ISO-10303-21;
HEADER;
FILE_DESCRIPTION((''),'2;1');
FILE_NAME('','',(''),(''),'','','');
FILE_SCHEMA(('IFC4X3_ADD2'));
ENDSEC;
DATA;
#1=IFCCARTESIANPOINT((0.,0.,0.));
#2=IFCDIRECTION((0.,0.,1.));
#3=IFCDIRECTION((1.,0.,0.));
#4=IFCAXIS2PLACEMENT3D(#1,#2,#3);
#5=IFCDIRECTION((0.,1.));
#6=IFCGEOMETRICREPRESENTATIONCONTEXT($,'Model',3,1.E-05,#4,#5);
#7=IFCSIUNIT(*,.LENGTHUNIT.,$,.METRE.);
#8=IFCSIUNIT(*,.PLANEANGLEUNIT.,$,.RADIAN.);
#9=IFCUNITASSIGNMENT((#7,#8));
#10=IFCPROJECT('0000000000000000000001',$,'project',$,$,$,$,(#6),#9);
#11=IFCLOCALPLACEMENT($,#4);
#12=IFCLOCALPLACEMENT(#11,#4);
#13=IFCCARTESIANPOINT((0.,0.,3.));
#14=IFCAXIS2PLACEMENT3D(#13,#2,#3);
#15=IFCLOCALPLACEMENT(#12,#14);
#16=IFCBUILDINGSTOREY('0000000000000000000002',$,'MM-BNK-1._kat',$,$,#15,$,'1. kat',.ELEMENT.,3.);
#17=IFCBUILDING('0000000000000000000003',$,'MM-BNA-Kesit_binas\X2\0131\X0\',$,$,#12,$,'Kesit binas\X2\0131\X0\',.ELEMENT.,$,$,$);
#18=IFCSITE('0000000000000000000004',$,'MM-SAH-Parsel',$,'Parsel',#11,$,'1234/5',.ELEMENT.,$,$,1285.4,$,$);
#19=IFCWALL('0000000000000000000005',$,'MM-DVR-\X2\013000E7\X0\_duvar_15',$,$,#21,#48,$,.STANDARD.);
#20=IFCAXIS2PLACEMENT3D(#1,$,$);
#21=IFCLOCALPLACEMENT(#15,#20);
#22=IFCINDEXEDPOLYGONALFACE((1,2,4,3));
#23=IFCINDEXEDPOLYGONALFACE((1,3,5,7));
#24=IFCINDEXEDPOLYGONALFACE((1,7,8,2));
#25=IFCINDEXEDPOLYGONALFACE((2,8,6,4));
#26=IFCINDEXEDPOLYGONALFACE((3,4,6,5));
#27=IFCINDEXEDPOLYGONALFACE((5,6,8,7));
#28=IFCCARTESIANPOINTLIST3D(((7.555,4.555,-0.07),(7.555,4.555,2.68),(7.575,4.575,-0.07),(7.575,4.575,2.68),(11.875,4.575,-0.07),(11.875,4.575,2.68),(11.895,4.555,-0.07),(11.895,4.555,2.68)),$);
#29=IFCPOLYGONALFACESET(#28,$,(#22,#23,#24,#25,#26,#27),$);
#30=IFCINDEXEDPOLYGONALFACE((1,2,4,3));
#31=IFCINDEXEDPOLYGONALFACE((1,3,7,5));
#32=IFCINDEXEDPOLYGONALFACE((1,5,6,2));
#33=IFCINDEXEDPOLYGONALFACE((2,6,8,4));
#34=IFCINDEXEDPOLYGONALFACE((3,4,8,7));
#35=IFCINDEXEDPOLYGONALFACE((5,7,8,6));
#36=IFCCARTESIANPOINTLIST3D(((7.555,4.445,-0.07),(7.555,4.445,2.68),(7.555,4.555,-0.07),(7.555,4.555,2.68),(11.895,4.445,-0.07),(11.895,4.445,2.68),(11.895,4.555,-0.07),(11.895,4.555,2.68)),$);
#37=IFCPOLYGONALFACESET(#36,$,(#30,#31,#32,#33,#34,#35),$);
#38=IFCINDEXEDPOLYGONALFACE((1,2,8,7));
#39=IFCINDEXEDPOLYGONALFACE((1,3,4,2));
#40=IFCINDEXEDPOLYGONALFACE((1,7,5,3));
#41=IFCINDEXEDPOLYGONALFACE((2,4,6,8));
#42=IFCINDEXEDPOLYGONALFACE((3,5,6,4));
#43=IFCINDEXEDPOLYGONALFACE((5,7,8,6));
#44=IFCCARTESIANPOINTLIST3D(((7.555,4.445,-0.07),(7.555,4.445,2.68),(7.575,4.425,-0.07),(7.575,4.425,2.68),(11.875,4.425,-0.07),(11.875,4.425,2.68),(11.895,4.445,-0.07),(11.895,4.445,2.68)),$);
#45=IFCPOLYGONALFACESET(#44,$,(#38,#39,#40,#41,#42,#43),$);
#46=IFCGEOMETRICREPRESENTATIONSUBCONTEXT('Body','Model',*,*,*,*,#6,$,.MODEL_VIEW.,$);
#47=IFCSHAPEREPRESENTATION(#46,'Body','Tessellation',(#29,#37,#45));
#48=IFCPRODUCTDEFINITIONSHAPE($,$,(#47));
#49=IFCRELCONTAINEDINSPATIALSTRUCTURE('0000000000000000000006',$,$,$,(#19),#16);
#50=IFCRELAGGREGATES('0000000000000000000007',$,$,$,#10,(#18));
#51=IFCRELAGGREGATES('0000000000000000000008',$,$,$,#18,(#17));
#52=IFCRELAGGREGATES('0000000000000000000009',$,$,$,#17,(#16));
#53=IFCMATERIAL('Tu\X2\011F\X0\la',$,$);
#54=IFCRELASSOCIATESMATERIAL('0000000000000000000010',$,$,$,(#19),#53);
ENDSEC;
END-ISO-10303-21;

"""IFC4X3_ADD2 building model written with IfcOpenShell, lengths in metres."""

from ifc_helpers import new_model, si_unit, direction, frame, origin_with_axes, place, context, subcontext, project, spatial, polyline, outline, extrude, material, element, save


model = new_model("IFC4X3_ADD2")

# Units and contexts
model_context = context("Model", 3, precision=1e-05, world=origin_with_axes(), true_north=direction((0.0, 1.0)))
body_context = subcontext(model_context, "Body", "Model", "MODEL_VIEW")
ifc_project = project(units=[si_unit("LENGTHUNIT", "METRE"), si_unit("PLANEANGLEUNIT", "RADIAN")], contexts=[model_context])

# Site, building, storey
site_placement = place(None, origin_with_axes())
site = spatial("IfcSite", under=ifc_project, at=site_placement, Name="MM-SAH-Parsel", ObjectType="Parsel", LongName="1234/5", CompositionType="ELEMENT", RefElevation=1285.4)
building_placement = place(site_placement, origin_with_axes())
building = spatial("IfcBuilding", under=site, at=building_placement, Name="MM-BNA-Kesit_binası", LongName="Kesit binası", CompositionType="ELEMENT")
storey_placement = place(building_placement, frame((0.0, 0.0, 3.0), z_axis=(0.0, 0.0, 1.0), x_axis=(1.0, 0.0, 0.0)))
storey = spatial("IfcBuildingStorey", under=building, at=storey_placement, Name="MM-BNK-1._kat", LongName="1. kat", CompositionType="ELEMENT", Elevation=3.0)

# Shared definitions
ifc_material_1 = material(Name="Tuğla")

# Wall
wall_1_placement = place(storey_placement, origin_with_axes())
element("IfcWall", 1, at=wall_1_placement, inside=storey, material=ifc_material_1, Name="MM-DVR-İç_duvar_15", PredefinedType="STANDARD", context=body_context, shape_type="SweptSolid", body=[
    extrude(outline(polyline([(7.575, 4.575), (11.875, 4.575), (11.895, 4.555), (7.555, 4.555), (7.575, 4.575)])), frame((0.0, 0.0, -0.07)), (0.0, 0.0, 1.0), 2.75),
    extrude(outline(polyline([(7.555, 4.555), (11.895, 4.555), (11.895, 4.445), (7.555, 4.445), (7.555, 4.555)])), frame((0.0, 0.0, -0.07)), (0.0, 0.0, 1.0), 2.75),
    extrude(outline(polyline([(7.555, 4.445), (11.895, 4.445), (11.875, 4.425), (7.575, 4.425), (7.555, 4.445)])), frame((0.0, 0.0, -0.07)), (0.0, 0.0, 1.0), 2.75),
])

save(model, "model.ifc")
